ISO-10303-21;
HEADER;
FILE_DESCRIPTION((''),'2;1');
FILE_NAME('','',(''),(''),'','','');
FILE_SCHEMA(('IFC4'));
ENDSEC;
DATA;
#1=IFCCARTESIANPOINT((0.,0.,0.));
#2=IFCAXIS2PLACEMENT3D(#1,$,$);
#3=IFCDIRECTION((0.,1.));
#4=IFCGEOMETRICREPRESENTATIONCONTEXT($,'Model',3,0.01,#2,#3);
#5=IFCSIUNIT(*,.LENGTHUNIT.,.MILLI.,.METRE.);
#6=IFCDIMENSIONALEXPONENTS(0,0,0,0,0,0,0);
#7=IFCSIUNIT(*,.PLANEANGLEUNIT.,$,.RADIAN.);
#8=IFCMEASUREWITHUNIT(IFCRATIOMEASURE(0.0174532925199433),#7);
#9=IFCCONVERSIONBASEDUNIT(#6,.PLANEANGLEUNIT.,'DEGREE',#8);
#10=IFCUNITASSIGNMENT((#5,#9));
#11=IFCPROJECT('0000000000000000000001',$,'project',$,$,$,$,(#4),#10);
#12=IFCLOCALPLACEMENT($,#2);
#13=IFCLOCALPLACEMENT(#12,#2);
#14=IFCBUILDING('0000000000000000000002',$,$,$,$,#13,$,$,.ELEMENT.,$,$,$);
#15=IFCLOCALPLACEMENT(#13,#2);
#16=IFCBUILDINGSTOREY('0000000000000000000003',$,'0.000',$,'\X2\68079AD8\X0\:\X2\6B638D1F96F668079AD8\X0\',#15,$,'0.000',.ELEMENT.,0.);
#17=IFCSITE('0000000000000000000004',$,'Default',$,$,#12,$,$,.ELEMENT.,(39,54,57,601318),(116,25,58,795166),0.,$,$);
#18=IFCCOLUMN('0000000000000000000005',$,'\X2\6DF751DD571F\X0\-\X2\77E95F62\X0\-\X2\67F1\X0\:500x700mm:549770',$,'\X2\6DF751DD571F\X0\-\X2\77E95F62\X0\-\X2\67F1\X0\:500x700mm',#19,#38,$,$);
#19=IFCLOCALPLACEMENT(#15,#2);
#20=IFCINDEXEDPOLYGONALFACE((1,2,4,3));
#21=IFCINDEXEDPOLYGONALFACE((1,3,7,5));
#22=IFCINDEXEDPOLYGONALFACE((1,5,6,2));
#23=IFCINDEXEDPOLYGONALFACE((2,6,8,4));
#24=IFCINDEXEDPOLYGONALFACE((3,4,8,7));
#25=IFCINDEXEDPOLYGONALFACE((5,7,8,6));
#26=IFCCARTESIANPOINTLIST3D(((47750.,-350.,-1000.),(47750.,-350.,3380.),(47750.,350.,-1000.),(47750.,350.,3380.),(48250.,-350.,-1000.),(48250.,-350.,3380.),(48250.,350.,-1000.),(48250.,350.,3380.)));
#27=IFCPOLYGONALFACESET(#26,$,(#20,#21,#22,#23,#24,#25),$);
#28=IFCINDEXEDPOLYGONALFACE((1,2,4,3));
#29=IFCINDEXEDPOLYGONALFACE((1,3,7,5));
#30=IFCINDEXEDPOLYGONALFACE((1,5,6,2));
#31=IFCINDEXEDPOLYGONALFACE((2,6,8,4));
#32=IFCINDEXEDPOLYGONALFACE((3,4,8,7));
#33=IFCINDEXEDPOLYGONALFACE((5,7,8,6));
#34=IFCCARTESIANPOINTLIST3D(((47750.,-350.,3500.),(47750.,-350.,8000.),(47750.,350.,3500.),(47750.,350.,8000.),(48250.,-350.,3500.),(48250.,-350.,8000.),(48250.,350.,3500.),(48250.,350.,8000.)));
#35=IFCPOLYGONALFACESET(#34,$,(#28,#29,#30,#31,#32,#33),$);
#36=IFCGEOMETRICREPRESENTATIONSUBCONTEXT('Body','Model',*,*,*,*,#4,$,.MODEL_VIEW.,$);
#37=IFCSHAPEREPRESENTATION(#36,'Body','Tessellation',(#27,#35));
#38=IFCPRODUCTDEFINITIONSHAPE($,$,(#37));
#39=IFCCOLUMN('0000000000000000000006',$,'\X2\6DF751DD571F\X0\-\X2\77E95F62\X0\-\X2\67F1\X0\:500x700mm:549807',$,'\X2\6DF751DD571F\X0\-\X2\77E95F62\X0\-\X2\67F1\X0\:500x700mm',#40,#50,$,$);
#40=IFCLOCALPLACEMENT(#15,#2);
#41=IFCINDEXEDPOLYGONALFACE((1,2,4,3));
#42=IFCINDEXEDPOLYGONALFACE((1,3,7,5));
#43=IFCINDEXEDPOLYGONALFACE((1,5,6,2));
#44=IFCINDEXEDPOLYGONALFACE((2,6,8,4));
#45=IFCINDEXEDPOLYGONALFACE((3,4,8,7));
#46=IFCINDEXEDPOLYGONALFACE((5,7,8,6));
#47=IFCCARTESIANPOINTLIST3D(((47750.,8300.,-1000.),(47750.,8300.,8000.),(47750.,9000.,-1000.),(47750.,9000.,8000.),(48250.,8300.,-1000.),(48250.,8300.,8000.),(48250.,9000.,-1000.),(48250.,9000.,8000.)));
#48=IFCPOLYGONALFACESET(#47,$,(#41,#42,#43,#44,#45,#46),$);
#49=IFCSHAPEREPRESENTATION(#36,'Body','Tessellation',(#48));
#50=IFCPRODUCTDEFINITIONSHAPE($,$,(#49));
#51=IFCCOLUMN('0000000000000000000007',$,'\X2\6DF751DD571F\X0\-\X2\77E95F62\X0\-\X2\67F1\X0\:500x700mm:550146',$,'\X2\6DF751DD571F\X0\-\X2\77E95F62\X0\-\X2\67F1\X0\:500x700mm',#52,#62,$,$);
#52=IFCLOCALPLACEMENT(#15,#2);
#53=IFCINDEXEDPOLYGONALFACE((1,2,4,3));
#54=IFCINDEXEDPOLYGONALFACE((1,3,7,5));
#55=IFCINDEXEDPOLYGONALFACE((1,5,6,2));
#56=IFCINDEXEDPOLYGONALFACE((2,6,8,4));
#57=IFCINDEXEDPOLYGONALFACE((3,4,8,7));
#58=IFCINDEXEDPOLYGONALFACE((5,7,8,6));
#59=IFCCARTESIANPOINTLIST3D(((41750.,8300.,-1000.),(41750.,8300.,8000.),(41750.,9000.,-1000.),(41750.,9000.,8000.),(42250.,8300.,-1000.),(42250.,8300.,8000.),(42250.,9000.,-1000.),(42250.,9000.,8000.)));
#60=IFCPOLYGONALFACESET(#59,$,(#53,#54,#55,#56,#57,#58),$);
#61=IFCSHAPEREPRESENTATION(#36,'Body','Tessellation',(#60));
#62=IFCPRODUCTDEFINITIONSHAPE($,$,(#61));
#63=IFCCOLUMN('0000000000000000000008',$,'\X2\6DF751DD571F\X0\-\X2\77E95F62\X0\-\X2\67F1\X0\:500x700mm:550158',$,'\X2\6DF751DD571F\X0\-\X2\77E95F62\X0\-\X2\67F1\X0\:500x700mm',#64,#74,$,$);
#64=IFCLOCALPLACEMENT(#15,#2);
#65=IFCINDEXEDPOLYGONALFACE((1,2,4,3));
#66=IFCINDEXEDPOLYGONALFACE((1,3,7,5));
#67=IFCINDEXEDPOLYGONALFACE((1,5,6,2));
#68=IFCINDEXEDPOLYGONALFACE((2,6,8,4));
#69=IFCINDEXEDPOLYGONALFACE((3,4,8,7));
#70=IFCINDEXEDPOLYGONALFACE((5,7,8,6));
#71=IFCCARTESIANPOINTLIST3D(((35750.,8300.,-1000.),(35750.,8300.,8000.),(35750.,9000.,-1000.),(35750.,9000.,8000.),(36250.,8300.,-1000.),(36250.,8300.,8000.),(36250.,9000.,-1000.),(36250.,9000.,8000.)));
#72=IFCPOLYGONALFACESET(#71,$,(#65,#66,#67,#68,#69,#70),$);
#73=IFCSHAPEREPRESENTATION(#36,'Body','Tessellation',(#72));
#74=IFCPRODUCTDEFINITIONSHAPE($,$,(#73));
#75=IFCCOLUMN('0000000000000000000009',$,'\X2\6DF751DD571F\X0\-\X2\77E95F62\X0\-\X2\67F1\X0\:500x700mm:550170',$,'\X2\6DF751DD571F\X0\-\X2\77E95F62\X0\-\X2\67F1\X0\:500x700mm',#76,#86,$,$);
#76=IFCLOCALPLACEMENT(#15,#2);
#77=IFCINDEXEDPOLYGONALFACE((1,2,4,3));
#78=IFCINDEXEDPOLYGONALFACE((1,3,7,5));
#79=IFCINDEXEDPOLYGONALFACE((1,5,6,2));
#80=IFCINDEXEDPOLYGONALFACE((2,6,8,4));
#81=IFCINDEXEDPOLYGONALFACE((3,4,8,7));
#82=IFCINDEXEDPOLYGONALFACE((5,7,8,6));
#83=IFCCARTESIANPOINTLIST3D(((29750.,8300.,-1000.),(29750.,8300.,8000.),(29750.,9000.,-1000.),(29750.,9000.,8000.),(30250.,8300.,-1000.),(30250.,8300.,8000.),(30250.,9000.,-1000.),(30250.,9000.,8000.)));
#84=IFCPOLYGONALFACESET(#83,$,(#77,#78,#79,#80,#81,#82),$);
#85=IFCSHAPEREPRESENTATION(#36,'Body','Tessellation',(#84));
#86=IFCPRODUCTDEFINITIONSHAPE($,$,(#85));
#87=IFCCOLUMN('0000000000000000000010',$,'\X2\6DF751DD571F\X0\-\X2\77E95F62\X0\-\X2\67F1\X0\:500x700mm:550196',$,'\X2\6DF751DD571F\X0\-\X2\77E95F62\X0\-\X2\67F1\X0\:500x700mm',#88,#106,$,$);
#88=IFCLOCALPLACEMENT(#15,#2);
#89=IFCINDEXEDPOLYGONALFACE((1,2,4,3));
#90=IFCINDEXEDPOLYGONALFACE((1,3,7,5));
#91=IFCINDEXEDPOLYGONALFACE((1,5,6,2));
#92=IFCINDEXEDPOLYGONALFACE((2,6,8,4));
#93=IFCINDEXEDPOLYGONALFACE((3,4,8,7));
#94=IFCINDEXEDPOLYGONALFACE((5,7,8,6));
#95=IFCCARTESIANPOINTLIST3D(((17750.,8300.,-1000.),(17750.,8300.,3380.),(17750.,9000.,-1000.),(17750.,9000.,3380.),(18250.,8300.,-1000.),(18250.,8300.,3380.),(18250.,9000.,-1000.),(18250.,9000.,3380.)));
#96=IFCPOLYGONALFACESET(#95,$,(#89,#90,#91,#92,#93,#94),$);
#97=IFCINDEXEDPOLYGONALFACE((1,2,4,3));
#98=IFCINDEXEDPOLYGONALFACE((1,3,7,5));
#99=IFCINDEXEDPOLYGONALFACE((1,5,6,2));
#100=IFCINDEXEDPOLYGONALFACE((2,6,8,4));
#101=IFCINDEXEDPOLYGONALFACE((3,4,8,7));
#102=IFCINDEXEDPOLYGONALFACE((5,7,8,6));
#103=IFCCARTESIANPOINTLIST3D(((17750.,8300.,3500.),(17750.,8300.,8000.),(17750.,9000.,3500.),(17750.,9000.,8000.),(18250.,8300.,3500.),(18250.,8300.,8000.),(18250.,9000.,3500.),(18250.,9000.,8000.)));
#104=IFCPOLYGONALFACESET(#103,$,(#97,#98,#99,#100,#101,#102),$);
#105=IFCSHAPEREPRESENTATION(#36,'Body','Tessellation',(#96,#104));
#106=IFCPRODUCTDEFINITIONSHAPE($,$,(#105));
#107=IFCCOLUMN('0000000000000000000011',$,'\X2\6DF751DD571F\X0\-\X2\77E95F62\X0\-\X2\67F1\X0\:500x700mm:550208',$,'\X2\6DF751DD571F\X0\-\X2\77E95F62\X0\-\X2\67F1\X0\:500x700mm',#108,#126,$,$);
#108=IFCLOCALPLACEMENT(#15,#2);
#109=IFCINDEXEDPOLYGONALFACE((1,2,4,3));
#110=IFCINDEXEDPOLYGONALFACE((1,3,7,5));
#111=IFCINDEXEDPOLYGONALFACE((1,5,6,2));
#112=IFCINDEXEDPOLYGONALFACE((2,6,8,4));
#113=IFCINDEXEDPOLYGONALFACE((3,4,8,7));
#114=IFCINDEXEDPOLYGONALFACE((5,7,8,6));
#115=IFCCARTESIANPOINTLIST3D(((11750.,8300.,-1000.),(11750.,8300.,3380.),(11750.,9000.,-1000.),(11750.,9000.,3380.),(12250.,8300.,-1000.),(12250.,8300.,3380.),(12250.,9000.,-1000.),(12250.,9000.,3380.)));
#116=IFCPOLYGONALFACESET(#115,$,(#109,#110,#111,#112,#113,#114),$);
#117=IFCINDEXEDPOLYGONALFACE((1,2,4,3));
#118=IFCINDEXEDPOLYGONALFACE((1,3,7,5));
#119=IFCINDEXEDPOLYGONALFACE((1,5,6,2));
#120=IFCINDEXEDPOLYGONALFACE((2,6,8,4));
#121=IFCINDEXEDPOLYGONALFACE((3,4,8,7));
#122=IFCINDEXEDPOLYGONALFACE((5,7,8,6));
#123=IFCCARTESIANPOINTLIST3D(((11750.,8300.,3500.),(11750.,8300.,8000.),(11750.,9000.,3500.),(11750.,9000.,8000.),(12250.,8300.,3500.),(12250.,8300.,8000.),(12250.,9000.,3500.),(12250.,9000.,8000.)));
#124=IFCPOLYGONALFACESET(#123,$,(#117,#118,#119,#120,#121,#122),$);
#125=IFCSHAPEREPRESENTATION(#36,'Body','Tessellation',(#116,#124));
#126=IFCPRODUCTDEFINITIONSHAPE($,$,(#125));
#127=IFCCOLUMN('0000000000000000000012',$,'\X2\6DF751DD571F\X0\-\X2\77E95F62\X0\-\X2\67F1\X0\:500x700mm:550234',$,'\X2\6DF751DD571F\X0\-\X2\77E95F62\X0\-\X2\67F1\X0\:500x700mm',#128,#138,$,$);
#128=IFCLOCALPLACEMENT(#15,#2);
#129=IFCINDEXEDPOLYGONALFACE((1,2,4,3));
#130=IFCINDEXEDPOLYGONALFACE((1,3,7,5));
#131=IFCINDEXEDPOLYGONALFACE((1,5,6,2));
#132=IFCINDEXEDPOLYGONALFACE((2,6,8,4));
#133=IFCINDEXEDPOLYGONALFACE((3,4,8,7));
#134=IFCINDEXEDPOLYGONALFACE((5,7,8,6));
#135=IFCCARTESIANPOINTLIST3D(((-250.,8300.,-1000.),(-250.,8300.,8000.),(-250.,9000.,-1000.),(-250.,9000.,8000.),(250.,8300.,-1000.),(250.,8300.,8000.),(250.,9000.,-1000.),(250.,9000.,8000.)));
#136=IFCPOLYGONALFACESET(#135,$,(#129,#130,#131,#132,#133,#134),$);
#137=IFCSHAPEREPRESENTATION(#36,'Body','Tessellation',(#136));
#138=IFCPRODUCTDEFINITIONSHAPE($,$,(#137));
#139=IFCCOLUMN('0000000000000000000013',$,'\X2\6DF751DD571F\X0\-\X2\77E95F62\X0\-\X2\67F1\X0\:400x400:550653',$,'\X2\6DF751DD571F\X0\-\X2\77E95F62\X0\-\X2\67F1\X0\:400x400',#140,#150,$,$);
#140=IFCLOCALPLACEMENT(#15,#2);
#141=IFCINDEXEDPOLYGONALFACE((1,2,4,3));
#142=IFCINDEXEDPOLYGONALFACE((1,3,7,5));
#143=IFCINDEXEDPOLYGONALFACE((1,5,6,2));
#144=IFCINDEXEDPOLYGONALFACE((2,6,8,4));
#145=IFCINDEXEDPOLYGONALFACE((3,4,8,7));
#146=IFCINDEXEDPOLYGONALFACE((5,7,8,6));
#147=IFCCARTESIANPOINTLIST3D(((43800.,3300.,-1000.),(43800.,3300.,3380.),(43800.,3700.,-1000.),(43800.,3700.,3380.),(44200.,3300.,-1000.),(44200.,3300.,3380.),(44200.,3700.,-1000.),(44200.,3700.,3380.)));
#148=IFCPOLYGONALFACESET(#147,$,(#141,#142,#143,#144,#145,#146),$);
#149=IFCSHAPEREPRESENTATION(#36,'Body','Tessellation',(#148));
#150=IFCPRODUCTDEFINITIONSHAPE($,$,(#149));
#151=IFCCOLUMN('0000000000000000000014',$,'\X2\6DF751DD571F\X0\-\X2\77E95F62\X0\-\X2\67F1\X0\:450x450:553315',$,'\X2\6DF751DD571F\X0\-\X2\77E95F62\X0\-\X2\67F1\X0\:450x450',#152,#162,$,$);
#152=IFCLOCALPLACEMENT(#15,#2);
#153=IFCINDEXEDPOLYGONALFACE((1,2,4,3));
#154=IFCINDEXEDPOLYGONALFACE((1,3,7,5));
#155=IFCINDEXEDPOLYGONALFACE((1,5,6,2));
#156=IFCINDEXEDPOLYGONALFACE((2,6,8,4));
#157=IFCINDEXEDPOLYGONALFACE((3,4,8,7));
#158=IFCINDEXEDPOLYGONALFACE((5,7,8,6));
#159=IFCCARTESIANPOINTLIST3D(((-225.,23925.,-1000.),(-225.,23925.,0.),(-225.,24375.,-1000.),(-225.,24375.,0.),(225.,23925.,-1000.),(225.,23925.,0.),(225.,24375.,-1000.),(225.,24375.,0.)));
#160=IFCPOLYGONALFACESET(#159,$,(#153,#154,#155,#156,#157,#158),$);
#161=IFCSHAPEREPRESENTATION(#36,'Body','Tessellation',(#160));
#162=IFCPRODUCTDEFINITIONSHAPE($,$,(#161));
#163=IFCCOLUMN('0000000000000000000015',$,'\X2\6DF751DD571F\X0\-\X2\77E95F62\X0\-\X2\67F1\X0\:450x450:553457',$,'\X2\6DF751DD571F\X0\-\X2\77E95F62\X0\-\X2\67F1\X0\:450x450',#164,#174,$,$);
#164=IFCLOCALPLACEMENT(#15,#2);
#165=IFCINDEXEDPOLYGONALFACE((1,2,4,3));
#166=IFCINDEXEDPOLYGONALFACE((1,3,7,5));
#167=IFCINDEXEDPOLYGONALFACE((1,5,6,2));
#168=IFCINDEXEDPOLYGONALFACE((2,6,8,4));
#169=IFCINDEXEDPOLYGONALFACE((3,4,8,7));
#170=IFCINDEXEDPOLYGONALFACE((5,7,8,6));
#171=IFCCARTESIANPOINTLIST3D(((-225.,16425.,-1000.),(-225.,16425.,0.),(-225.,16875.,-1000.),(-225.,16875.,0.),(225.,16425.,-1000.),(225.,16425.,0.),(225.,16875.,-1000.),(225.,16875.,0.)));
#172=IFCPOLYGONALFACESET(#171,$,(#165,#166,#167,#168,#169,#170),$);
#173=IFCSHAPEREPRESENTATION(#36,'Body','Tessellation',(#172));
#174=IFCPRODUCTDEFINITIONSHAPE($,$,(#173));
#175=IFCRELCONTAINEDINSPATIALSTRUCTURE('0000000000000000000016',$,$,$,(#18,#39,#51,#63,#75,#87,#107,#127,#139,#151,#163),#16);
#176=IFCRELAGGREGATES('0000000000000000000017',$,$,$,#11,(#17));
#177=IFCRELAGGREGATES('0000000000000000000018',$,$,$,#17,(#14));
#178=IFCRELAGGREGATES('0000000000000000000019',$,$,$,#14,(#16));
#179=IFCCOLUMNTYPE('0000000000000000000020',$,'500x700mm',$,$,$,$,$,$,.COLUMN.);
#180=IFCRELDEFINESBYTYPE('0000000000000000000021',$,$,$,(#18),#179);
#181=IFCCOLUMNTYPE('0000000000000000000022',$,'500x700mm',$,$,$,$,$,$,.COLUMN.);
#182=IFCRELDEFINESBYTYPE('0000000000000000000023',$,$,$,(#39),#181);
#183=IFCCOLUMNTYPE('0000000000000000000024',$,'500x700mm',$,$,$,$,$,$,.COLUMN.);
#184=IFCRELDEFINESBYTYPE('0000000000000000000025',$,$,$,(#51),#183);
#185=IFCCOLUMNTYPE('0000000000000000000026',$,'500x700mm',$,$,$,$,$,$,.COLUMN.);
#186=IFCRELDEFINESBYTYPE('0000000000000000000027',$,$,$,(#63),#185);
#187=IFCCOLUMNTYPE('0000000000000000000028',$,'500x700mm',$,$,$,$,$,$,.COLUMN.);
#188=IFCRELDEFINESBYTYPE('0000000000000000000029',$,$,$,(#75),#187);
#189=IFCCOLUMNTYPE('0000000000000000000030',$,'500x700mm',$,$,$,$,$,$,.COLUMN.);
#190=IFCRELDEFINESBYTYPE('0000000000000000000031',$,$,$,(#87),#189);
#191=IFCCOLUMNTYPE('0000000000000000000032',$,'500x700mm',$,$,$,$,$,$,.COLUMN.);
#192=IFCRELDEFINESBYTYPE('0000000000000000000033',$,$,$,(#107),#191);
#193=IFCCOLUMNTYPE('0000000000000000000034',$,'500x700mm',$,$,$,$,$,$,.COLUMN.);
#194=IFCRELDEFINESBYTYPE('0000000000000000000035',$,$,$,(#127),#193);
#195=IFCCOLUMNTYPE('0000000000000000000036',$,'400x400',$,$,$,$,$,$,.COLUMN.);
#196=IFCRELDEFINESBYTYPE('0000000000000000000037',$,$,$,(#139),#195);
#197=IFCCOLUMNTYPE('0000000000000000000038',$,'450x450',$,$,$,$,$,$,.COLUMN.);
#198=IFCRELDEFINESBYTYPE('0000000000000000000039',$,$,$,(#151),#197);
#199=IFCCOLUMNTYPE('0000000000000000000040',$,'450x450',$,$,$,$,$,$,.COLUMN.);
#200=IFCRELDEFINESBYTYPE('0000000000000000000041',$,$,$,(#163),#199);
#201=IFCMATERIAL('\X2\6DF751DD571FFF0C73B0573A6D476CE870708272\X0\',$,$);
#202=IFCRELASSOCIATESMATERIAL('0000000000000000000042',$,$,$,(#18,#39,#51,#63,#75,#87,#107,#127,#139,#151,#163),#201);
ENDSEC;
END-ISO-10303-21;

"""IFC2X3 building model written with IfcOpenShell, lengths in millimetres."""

from ifc_helpers import new_model, entity, si_unit, converted_unit, direction, frame, frame_2d, origin, origin_2d_with_axis, place, context, subcontext, project, spatial, rectangle, extrude, source, transform, mapped, material, type_object, type_shapes, element, save


model = new_model("IFC2X3")

# Units and contexts
model_context = context("Model", 3, precision=0.01, world=origin(), true_north=direction((0.0, 1.0)))
body_context = subcontext(model_context, "Body", "Model", "MODEL_VIEW")
ifc_project = project(units=[si_unit("LENGTHUNIT", "METRE", prefix="MILLI"), converted_unit("PLANEANGLEUNIT", "DEGREE", entity("IfcRatioMeasure", 0.0174532925199433), si_unit("PLANEANGLEUNIT", "RADIAN"), dimensions=[0, 0, 0, 0, 0, 0, 0])], contexts=[model_context])

# Site, building, storey
site_placement = place(None, origin())
site = spatial("IfcSite", under=ifc_project, at=site_placement, Name="Default", CompositionType="ELEMENT", RefLatitude=(39, 54, 57, 601318), RefLongitude=(116, 25, 58, 795166), RefElevation=0.0)
building_placement = place(site_placement, origin())
building = spatial("IfcBuilding", under=site, at=building_placement, CompositionType="ELEMENT")
storey_placement = place(building_placement, origin())
storey = spatial("IfcBuildingStorey", under=building, at=storey_placement, Name="0.000", ObjectType="标高:正负零标高", LongName="0.000", CompositionType="ELEMENT", Elevation=0.0)

# Columns
ifc_material_1 = material(Name="混凝土，现场浇注灰色")
column_type_1 = type_object("IfcColumnType", Name="500x700mm", PredefinedType="COLUMN")
shared_shape_1 = source(origin(), body_context, "Body", "SweptSolid", [
    extrude(rectangle(XDim=700.0, YDim=500.0, at=origin_2d_with_axis()), frame((48000.0, 0.0, -1000.0), z_axis=(0.0, 0.0, 1.0), x_axis=(0.0, -1.0, 0.0)), (0.0, 0.0, 1.0), 4380.0),
    extrude(rectangle(XDim=700.0, YDim=500.0, at=origin_2d_with_axis()), frame((48000.0, 0.0, 3500.0), z_axis=(0.0, 0.0, 1.0), x_axis=(0.0, -1.0, 0.0)), (0.0, 0.0, 1.0), 4500.0),
])
type_shapes(column_type_1, [shared_shape_1])
column_1_placement = place(storey_placement, origin())
element("IfcColumn", 1, at=column_1_placement, inside=storey, type_object=column_type_1, material=ifc_material_1, Name="混凝土-矩形-柱:500x700mm:549770", ObjectType="混凝土-矩形-柱:500x700mm", context=body_context, shape_type="MappedRepresentation", body=[
    mapped(shared_shape_1, transform((0.0, 0.0, 0.0), scale=1.0)),
])
column_type_2 = type_object("IfcColumnType", Name="500x700mm", PredefinedType="COLUMN")
shared_shape_2 = source(origin(), body_context, "Body", "SweptSolid", [
    extrude(rectangle(XDim=700.0, YDim=500.0, at=frame_2d((0.0, 0.0), x_axis=(1.0, 0.0))), frame((48000.0, 8650.0, -1000.0), z_axis=(0.0, 0.0, 1.0), x_axis=(0.0, -1.0, 0.0)), (0.0, 0.0, 1.0), 9000.0),
])
type_shapes(column_type_2, [shared_shape_2])
column_2_placement = place(storey_placement, origin())
element("IfcColumn", 2, at=column_2_placement, inside=storey, type_object=column_type_2, material=ifc_material_1, Name="混凝土-矩形-柱:500x700mm:549807", ObjectType="混凝土-矩形-柱:500x700mm", context=body_context, shape_type="MappedRepresentation", body=[
    mapped(shared_shape_2, transform((0.0, 0.0, 0.0), scale=1.0)),
])
column_type_3 = type_object("IfcColumnType", Name="500x700mm", PredefinedType="COLUMN")
shared_shape_3 = source(origin(), body_context, "Body", "SweptSolid", [
    extrude(rectangle(XDim=700.0, YDim=500.0, at=origin_2d_with_axis()), frame((42000.0, 8650.0, -1000.0), z_axis=(0.0, 0.0, 1.0), x_axis=(0.0, -1.0, 0.0)), (0.0, 0.0, 1.0), 9000.0),
])
type_shapes(column_type_3, [shared_shape_3])
column_3_placement = place(storey_placement, origin())
element("IfcColumn", 3, at=column_3_placement, inside=storey, type_object=column_type_3, material=ifc_material_1, Name="混凝土-矩形-柱:500x700mm:550146", ObjectType="混凝土-矩形-柱:500x700mm", context=body_context, shape_type="MappedRepresentation", body=[
    mapped(shared_shape_3, transform((0.0, 0.0, 0.0), scale=1.0)),
])
column_type_4 = type_object("IfcColumnType", Name="500x700mm", PredefinedType="COLUMN")
shared_shape_4 = source(origin(), body_context, "Body", "SweptSolid", [
    extrude(rectangle(XDim=700.0, YDim=500.0, at=frame_2d((0.0, 0.0), x_axis=(1.0, 0.0))), frame((36000.0, 8650.0, -1000.0), z_axis=(0.0, 0.0, 1.0), x_axis=(0.0, -1.0, 0.0)), (0.0, 0.0, 1.0), 9000.0),
])
type_shapes(column_type_4, [shared_shape_4])
column_4_placement = place(storey_placement, origin())
element("IfcColumn", 4, at=column_4_placement, inside=storey, type_object=column_type_4, material=ifc_material_1, Name="混凝土-矩形-柱:500x700mm:550158", ObjectType="混凝土-矩形-柱:500x700mm", context=body_context, shape_type="MappedRepresentation", body=[
    mapped(shared_shape_4, transform((0.0, 0.0, 0.0), scale=1.0)),
])
column_type_5 = type_object("IfcColumnType", Name="500x700mm", PredefinedType="COLUMN")
shared_shape_5 = source(origin(), body_context, "Body", "SweptSolid", [
    extrude(rectangle(XDim=700.0, YDim=500.0, at=origin_2d_with_axis()), frame((30000.0, 8650.0, -1000.0), z_axis=(0.0, 0.0, 1.0), x_axis=(0.0, -1.0, 0.0)), (0.0, 0.0, 1.0), 9000.0),
])
type_shapes(column_type_5, [shared_shape_5])
column_5_placement = place(storey_placement, origin())
element("IfcColumn", 5, at=column_5_placement, inside=storey, type_object=column_type_5, material=ifc_material_1, Name="混凝土-矩形-柱:500x700mm:550170", ObjectType="混凝土-矩形-柱:500x700mm", context=body_context, shape_type="MappedRepresentation", body=[
    mapped(shared_shape_5, transform((0.0, 0.0, 0.0), scale=1.0)),
])
column_type_6 = type_object("IfcColumnType", Name="500x700mm", PredefinedType="COLUMN")
shared_shape_6 = source(origin(), body_context, "Body", "SweptSolid", [
    extrude(rectangle(XDim=700.0, YDim=500.0, at=origin_2d_with_axis()), frame((18000.0, 8650.0, -1000.0), z_axis=(0.0, 0.0, 1.0), x_axis=(0.0, -1.0, 0.0)), (0.0, 0.0, 1.0), 4380.0),
    extrude(rectangle(XDim=700.0, YDim=500.0, at=origin_2d_with_axis()), frame((18000.0, 8650.0, 3500.0), z_axis=(0.0, 0.0, 1.0), x_axis=(0.0, -1.0, 0.0)), (0.0, 0.0, 1.0), 4500.0),
])
type_shapes(column_type_6, [shared_shape_6])
column_6_placement = place(storey_placement, origin())
element("IfcColumn", 6, at=column_6_placement, inside=storey, type_object=column_type_6, material=ifc_material_1, Name="混凝土-矩形-柱:500x700mm:550196", ObjectType="混凝土-矩形-柱:500x700mm", context=body_context, shape_type="MappedRepresentation", body=[
    mapped(shared_shape_6, transform((0.0, 0.0, 0.0), scale=1.0)),
])
column_type_7 = type_object("IfcColumnType", Name="500x700mm", PredefinedType="COLUMN")
shared_shape_7 = source(origin(), body_context, "Body", "SweptSolid", [
    extrude(rectangle(XDim=700.0, YDim=500.0, at=frame_2d((0.0, 0.0), x_axis=(1.0, 0.0))), frame((12000.0, 8650.0, -1000.0), z_axis=(0.0, 0.0, 1.0), x_axis=(0.0, -1.0, 0.0)), (0.0, 0.0, 1.0), 4380.0),
    extrude(rectangle(XDim=700.0, YDim=500.0, at=frame_2d((0.0, 0.0), x_axis=(1.0, 0.0))), frame((12000.0, 8650.0, 3500.0), z_axis=(0.0, 0.0, 1.0), x_axis=(0.0, -1.0, 0.0)), (0.0, 0.0, 1.0), 4500.0),
])
type_shapes(column_type_7, [shared_shape_7])
column_7_placement = place(storey_placement, origin())
element("IfcColumn", 7, at=column_7_placement, inside=storey, type_object=column_type_7, material=ifc_material_1, Name="混凝土-矩形-柱:500x700mm:550208", ObjectType="混凝土-矩形-柱:500x700mm", context=body_context, shape_type="MappedRepresentation", body=[
    mapped(shared_shape_7, transform((0.0, 0.0, 0.0), scale=1.0)),
])
column_type_8 = type_object("IfcColumnType", Name="500x700mm", PredefinedType="COLUMN")
shared_shape_8 = source(origin(), body_context, "Body", "SweptSolid", [
    extrude(rectangle(XDim=700.0, YDim=500.0, at=frame_2d((0.0, 0.0), x_axis=(1.0, 0.0))), frame((0.0, 8650.0, -1000.0), z_axis=(0.0, 0.0, 1.0), x_axis=(0.0, -1.0, 0.0)), (0.0, 0.0, 1.0), 9000.0),
])
type_shapes(column_type_8, [shared_shape_8])
column_8_placement = place(storey_placement, origin())
element("IfcColumn", 8, at=column_8_placement, inside=storey, type_object=column_type_8, material=ifc_material_1, Name="混凝土-矩形-柱:500x700mm:550234", ObjectType="混凝土-矩形-柱:500x700mm", context=body_context, shape_type="MappedRepresentation", body=[
    mapped(shared_shape_8, transform((0.0, 0.0, 0.0), scale=1.0)),
])
column_type_9 = type_object("IfcColumnType", Name="400x400", PredefinedType="COLUMN")
shared_shape_9 = source(origin(), body_context, "Body", "SweptSolid", [
    extrude(rectangle(XDim=400.0, YDim=400.0, at=origin_2d_with_axis()), frame((44000.0, 3500.0, -1000.0), z_axis=(0.0, 0.0, 1.0), x_axis=(0.0, -1.0, 0.0)), (0.0, 0.0, 1.0), 4380.0),
])
type_shapes(column_type_9, [shared_shape_9])
column_9_placement = place(storey_placement, origin())
element("IfcColumn", 9, at=column_9_placement, inside=storey, type_object=column_type_9, material=ifc_material_1, Name="混凝土-矩形-柱:400x400:550653", ObjectType="混凝土-矩形-柱:400x400", context=body_context, shape_type="MappedRepresentation", body=[
    mapped(shared_shape_9, transform((0.0, 0.0, 0.0), scale=1.0)),
])
column_type_10 = type_object("IfcColumnType", Name="450x450", PredefinedType="COLUMN")
shared_shape_10 = source(origin(), body_context, "Body", "SweptSolid", [
    extrude(rectangle(XDim=450.0, YDim=450.0, at=origin_2d_with_axis()), frame((0.0, 24150.0, -1000.0), z_axis=(0.0, 0.0, 1.0), x_axis=(0.0, -1.0, 0.0)), (0.0, 0.0, 1.0), 1000.0),
])
type_shapes(column_type_10, [shared_shape_10])
column_10_placement = place(storey_placement, origin())
element("IfcColumn", 10, at=column_10_placement, inside=storey, type_object=column_type_10, material=ifc_material_1, Name="混凝土-矩形-柱:450x450:553315", ObjectType="混凝土-矩形-柱:450x450", context=body_context, shape_type="MappedRepresentation", body=[
    mapped(shared_shape_10, transform((0.0, 0.0, 0.0), scale=1.0)),
])
column_type_11 = type_object("IfcColumnType", Name="450x450", PredefinedType="COLUMN")
shared_shape_11 = source(origin(), body_context, "Body", "SweptSolid", [
    extrude(rectangle(XDim=450.0, YDim=450.0, at=origin_2d_with_axis()), frame((0.0, 16650.0, -1000.0), z_axis=(0.0, 0.0, 1.0), x_axis=(0.0, -1.0, 0.0)), (0.0, 0.0, 1.0), 1000.0),
])
type_shapes(column_type_11, [shared_shape_11])
column_11_placement = place(storey_placement, origin())
element("IfcColumn", 11, at=column_11_placement, inside=storey, type_object=column_type_11, material=ifc_material_1, Name="混凝土-矩形-柱:450x450:553457", ObjectType="混凝土-矩形-柱:450x450", context=body_context, shape_type="MappedRepresentation", body=[
    mapped(shared_shape_11, transform((0.0, 0.0, 0.0), scale=1.0)),
])

save(model, "model.ifc")
